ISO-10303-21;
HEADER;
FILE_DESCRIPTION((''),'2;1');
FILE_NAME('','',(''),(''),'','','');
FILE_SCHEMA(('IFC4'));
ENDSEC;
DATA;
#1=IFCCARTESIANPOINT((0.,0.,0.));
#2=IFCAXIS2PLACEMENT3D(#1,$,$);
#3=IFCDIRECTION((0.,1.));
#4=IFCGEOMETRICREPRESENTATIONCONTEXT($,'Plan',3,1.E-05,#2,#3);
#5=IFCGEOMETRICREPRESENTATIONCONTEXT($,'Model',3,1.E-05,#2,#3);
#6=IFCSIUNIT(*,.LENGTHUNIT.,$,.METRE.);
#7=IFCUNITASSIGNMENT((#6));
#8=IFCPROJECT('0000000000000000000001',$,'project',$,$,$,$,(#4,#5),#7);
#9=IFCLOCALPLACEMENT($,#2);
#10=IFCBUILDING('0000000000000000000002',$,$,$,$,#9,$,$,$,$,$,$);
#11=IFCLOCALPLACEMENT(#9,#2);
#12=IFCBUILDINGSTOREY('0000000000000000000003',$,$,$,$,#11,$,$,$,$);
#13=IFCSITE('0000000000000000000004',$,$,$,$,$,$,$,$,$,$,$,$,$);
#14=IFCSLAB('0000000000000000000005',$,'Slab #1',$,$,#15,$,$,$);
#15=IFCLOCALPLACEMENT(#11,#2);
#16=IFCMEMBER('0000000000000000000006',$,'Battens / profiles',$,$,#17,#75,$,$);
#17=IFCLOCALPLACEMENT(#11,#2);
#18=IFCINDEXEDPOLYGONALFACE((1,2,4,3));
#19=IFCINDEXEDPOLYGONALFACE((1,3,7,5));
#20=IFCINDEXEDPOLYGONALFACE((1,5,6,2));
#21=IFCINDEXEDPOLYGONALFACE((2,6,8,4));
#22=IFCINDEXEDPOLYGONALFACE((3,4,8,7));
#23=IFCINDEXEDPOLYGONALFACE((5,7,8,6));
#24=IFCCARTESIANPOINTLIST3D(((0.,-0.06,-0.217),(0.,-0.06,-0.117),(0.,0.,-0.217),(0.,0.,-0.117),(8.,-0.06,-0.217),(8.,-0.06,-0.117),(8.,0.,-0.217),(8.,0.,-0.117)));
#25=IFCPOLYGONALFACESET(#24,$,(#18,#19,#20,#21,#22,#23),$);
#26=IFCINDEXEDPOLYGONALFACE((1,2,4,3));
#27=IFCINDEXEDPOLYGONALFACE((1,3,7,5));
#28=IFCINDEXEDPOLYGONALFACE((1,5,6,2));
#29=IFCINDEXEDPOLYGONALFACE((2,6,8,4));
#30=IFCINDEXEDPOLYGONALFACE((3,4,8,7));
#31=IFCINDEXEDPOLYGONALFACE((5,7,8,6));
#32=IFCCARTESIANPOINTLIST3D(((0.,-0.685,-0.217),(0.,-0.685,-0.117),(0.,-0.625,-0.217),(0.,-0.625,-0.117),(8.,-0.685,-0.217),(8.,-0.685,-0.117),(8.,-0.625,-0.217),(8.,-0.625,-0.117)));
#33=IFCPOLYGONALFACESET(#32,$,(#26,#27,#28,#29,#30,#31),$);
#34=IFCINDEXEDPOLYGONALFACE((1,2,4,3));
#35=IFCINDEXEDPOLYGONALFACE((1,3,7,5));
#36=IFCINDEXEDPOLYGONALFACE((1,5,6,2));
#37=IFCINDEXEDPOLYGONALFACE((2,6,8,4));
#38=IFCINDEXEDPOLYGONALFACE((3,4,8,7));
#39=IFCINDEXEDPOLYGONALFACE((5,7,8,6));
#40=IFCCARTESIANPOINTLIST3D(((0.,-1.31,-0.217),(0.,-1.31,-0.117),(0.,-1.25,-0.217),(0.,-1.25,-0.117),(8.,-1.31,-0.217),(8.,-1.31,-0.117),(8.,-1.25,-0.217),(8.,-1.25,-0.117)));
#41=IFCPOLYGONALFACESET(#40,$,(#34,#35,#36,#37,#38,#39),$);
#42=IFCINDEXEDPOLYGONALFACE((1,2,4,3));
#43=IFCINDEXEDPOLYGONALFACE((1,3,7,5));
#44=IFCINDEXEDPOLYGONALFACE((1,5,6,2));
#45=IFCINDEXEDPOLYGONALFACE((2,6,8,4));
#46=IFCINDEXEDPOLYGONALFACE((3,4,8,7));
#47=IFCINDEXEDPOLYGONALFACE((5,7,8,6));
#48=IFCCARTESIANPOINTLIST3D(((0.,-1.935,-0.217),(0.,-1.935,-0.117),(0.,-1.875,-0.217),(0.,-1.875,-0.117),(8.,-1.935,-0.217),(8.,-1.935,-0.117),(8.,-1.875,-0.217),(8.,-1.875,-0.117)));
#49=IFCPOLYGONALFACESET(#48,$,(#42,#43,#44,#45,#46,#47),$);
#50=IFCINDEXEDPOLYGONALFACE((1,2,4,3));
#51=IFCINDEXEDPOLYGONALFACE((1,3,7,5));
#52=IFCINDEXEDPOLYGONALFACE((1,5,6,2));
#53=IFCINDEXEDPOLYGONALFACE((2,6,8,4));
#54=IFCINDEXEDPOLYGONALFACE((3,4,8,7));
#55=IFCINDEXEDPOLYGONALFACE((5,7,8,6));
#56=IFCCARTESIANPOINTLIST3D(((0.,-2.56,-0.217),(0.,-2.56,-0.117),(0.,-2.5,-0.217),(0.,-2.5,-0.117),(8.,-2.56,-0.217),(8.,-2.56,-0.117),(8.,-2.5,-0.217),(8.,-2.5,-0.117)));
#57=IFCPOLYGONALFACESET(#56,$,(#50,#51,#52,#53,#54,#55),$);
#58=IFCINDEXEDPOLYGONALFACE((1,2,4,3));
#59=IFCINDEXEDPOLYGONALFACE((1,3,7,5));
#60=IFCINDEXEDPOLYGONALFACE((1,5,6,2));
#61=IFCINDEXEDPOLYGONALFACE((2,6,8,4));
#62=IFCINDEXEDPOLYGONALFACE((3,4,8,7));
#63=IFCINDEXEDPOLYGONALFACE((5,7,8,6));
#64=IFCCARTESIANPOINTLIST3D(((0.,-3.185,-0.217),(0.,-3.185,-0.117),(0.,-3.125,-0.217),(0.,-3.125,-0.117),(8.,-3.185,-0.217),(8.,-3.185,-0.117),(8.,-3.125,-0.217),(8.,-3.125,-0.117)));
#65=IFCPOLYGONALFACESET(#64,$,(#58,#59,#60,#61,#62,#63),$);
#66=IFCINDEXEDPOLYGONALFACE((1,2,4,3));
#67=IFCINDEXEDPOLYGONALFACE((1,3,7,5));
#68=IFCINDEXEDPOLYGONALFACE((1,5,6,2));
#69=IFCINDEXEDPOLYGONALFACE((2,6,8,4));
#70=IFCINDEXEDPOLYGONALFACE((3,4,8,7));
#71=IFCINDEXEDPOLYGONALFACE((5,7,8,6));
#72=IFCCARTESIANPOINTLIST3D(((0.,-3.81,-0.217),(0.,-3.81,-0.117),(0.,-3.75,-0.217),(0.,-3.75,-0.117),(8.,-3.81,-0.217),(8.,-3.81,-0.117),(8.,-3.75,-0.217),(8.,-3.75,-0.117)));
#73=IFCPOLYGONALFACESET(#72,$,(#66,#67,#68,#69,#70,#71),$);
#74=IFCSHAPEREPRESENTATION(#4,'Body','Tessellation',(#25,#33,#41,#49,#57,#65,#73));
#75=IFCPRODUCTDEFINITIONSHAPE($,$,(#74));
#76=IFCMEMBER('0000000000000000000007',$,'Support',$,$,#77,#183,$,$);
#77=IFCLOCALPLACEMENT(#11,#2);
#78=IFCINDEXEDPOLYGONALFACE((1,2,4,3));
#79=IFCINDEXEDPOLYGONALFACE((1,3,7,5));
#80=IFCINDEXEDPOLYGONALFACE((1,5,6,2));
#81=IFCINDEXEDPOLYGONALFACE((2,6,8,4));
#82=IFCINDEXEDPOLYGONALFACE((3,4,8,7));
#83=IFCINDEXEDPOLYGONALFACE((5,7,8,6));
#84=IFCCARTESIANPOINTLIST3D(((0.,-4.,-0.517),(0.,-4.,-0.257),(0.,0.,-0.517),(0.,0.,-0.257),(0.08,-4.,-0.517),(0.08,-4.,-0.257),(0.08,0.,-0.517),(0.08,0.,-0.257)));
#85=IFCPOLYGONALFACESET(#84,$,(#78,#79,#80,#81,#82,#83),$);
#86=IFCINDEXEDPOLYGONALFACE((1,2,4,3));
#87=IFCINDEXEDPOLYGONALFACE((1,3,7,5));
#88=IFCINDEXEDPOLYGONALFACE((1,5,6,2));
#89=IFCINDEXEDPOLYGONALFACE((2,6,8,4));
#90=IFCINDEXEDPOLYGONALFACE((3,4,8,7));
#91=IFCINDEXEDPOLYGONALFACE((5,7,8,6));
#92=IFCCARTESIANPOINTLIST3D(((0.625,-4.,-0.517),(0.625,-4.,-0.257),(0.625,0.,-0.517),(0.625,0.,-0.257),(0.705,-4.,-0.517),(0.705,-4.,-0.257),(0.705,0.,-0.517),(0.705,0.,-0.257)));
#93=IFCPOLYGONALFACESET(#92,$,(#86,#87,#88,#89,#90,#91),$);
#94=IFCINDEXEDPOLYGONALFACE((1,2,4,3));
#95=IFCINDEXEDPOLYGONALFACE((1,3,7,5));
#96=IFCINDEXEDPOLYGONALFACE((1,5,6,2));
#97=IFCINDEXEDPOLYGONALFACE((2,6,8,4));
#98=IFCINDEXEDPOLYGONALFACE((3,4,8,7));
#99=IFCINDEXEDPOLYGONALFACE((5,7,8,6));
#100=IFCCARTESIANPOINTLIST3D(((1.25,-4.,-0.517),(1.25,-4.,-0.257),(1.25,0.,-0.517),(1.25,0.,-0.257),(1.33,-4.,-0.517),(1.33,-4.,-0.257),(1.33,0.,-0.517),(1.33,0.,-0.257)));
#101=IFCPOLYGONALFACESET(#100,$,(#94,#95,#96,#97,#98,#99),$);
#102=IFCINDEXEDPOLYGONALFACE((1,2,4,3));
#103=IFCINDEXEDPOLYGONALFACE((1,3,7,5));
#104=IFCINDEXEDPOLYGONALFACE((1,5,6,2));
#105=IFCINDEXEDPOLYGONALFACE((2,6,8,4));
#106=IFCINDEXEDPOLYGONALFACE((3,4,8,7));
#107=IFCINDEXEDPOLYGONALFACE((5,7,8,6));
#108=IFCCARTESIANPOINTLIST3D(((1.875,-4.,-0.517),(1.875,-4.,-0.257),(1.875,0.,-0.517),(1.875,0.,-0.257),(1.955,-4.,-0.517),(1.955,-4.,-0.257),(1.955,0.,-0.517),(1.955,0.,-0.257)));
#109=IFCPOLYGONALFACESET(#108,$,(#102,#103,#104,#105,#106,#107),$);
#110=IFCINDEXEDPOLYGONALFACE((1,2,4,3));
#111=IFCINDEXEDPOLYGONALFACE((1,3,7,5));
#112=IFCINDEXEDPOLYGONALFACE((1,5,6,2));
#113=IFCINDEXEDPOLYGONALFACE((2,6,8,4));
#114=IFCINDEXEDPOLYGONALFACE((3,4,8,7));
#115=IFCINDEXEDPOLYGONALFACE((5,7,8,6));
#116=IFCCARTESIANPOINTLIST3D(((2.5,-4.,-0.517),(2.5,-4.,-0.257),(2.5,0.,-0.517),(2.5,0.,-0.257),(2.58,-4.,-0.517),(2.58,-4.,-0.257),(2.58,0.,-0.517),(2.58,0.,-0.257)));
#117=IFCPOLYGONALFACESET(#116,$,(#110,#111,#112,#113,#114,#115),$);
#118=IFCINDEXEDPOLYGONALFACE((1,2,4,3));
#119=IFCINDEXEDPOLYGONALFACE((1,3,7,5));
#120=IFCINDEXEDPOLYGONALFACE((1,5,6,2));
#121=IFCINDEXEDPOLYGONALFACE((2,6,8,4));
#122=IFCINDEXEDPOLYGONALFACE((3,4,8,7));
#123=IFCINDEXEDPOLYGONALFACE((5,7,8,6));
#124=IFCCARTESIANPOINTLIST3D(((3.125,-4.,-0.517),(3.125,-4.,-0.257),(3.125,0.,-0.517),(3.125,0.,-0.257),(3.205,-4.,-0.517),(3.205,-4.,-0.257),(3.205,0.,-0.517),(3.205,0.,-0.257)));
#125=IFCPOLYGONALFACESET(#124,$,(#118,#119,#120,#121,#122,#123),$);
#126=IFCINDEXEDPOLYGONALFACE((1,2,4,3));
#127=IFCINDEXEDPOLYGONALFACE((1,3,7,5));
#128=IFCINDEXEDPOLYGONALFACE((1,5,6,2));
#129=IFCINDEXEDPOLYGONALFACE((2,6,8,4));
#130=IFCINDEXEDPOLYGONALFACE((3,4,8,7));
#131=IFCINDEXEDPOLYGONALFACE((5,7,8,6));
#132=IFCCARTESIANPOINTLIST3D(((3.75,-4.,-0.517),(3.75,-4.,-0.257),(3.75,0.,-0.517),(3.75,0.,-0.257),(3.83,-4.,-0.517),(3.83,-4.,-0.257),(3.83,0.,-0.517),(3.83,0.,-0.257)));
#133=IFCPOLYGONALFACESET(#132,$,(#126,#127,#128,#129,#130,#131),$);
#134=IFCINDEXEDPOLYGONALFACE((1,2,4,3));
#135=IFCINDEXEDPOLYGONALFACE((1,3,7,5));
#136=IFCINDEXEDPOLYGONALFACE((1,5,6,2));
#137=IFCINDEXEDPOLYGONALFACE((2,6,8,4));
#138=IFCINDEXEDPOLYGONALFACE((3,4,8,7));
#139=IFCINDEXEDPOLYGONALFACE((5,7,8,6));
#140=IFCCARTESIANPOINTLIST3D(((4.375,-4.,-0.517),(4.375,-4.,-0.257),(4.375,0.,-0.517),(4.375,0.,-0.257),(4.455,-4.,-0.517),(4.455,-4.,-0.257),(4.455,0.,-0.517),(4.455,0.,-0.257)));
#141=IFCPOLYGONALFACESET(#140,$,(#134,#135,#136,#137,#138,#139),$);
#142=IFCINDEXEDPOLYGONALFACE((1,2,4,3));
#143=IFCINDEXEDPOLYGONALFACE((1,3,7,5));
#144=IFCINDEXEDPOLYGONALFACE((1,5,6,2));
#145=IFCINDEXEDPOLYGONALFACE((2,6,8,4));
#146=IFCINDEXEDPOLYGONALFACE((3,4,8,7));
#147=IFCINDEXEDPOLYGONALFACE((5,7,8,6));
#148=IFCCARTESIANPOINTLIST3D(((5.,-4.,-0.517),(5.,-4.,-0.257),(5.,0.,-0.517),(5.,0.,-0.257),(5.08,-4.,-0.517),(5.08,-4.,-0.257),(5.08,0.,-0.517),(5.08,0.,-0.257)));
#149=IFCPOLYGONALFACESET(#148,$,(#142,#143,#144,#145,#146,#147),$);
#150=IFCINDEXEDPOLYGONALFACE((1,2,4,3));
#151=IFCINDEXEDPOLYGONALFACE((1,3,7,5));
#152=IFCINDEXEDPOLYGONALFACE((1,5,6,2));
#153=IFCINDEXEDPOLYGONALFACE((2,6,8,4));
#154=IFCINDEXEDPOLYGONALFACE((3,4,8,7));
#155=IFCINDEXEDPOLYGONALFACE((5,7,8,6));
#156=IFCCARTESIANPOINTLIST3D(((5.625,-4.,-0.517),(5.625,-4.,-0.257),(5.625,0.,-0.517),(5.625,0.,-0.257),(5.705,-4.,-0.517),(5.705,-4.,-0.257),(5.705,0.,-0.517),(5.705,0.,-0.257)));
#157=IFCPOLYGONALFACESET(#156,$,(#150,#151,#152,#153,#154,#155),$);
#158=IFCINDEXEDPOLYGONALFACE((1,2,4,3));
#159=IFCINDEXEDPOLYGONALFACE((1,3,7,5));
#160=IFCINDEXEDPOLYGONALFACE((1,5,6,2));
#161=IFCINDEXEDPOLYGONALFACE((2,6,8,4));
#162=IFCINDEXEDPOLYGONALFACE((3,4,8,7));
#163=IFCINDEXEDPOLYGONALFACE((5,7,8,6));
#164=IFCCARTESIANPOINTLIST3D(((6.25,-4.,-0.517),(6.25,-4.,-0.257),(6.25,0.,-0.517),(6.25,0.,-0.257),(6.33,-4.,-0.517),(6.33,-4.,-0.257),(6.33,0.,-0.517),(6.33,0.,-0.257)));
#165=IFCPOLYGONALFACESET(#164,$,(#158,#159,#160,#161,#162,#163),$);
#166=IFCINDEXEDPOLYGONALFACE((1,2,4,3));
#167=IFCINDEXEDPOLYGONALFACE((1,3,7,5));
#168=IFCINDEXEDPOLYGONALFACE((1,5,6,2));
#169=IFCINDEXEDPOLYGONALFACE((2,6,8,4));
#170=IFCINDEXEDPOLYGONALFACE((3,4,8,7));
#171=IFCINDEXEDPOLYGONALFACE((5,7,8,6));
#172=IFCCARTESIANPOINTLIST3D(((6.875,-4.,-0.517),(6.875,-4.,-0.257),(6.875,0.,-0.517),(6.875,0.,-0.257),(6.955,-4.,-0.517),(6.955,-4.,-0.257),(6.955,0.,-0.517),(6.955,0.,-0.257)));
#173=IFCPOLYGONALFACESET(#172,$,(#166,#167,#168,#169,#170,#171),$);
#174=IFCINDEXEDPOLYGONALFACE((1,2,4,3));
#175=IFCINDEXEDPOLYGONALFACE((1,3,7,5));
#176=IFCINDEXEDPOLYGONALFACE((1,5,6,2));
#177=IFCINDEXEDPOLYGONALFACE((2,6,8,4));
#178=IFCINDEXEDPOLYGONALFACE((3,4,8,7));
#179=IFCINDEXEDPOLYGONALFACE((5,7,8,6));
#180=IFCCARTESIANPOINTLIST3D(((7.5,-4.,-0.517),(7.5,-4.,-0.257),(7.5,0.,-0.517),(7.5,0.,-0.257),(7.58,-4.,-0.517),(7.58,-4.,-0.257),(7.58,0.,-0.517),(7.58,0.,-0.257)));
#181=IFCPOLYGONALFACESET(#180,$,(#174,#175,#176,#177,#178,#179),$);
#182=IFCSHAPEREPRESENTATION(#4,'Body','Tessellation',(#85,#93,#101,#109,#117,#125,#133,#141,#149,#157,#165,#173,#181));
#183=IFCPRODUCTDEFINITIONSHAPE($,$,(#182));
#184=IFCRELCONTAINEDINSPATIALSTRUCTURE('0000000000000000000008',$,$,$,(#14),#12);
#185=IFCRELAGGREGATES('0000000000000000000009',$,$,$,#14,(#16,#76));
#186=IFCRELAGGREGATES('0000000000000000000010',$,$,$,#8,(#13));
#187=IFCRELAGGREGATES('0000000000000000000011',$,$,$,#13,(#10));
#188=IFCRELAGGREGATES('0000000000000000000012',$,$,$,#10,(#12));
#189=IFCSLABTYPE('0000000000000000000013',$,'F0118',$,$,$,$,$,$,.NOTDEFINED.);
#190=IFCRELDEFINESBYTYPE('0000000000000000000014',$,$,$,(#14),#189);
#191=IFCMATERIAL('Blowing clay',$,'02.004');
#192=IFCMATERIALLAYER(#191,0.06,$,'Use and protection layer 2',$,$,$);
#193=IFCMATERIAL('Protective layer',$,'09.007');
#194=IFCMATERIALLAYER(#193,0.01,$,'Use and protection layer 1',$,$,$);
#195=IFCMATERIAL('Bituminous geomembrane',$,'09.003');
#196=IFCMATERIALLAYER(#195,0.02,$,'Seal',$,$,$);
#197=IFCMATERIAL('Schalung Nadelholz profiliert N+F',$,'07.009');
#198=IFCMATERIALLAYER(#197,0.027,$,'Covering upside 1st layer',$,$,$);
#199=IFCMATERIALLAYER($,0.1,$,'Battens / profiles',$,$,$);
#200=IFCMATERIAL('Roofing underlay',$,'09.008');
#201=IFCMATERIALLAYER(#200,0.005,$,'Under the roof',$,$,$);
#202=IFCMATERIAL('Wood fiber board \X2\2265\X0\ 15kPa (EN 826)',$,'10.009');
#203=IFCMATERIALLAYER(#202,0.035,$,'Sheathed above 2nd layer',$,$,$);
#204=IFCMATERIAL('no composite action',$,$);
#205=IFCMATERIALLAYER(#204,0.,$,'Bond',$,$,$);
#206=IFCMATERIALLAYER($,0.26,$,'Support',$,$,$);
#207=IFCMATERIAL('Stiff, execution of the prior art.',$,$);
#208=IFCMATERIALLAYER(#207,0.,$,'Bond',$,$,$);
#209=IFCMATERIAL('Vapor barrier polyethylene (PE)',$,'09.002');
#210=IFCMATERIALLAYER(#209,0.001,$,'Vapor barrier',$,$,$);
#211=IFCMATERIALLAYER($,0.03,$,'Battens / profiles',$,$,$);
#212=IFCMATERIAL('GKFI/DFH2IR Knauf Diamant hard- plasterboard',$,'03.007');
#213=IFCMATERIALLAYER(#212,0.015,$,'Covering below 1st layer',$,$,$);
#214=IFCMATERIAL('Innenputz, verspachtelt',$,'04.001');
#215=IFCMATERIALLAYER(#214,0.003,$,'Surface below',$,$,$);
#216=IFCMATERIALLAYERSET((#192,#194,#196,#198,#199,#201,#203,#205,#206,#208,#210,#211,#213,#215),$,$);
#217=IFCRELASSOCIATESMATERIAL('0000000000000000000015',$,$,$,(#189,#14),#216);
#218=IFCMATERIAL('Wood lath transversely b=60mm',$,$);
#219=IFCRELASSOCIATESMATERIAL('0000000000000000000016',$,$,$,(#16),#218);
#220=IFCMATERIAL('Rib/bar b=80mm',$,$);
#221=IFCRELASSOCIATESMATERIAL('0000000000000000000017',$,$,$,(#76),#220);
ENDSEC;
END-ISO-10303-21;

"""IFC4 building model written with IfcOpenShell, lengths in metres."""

from ifc_helpers import new_model, si_unit, direction, frame, frame_2d, origin, place, context, project, spatial, rectangle, extrude, material, layer, layer_set, type_object, element, aggregate, save


model = new_model("IFC4")

# Units and contexts
plan_context = context("Plan", 3, precision=1e-05, world=origin(), true_north=direction((0.0, 1.0)))
model_context = context("Model", 3, precision=1e-05, world=origin(), true_north=direction((0.0, 1.0)))
ifc_project = project(units=[si_unit("LENGTHUNIT", "METRE")], contexts=[plan_context, model_context])

# Site, building, storey
site = spatial("IfcSite", under=ifc_project)
building_placement = place(None, origin())
building = spatial("IfcBuilding", under=site, at=building_placement)
storey_placement = place(building_placement, origin())
storey = spatial("IfcBuildingStorey", under=building, at=storey_placement)

# Slab, members
ifc_material_1 = material(Name="Blowing clay", Category="02.004")
ifc_layer_1 = layer(ifc_material_1, 0.06, Name="Use and protection layer 2")
ifc_material_2 = material(Name="Protective layer", Category="09.007")
ifc_layer_2 = layer(ifc_material_2, 0.01, Name="Use and protection layer 1")
ifc_material_3 = material(Name="Bituminous geomembrane", Category="09.003")
ifc_layer_3 = layer(ifc_material_3, 0.02, Name="Seal")
ifc_material_4 = material(Name="Schalung Nadelholz profiliert N+F", Category="07.009")
ifc_layer_4 = layer(ifc_material_4, 0.027, Name="Covering upside 1st layer")
ifc_layer_5 = layer(None, 0.1, Name="Battens / profiles")
ifc_material_5 = material(Name="Roofing underlay", Category="09.008")
ifc_layer_6 = layer(ifc_material_5, 0.005, Name="Under the roof")
ifc_material_6 = material(Name="Wood fiber board ≥ 15kPa (EN 826)", Category="10.009")
ifc_layer_7 = layer(ifc_material_6, 0.035, Name="Sheathed above 2nd layer")
ifc_material_7 = material(Name="no composite action")
ifc_layer_8 = layer(ifc_material_7, 0.0, Name="Bond")
ifc_layer_9 = layer(None, 0.26, Name="Support")
ifc_material_8 = material(Name="Stiff, execution of the prior art.")
ifc_layer_10 = layer(ifc_material_8, 0.0, Name="Bond")
ifc_material_9 = material(Name="Vapor barrier polyethylene (PE)", Category="09.002")
ifc_layer_11 = layer(ifc_material_9, 0.001, Name="Vapor barrier")
ifc_layer_12 = layer(None, 0.03, Name="Battens / profiles")
ifc_material_10 = material(Name="GKFI/DFH2IR Knauf Diamant hard- plasterboard", Category="03.007")
ifc_layer_13 = layer(ifc_material_10, 0.015, Name="Covering below 1st layer")
ifc_material_11 = material(Name="Innenputz, verspachtelt", Category="04.001")
ifc_layer_14 = layer(ifc_material_11, 0.003, Name="Surface below")
ifc_layer_set = layer_set([ifc_layer_1, ifc_layer_2, ifc_layer_3, ifc_layer_4, ifc_layer_5, ifc_layer_6, ifc_layer_7, ifc_layer_8, ifc_layer_9, ifc_layer_10, ifc_layer_11, ifc_layer_12, ifc_layer_13, ifc_layer_14])
slab_type = type_object("IfcSlabType", Name="F0118", PredefinedType="NOTDEFINED", material=ifc_layer_set)
slab_placement = place(None, frame((0.0, 0.0, 0.0), z_axis=(0.0, 0.0, -1.0), x_axis=(1.0, 0.0, 0.0)))
slab = element("IfcSlab", 1, at=slab_placement, inside=storey, type_object=slab_type, material=ifc_layer_set, Name="Slab #1")
ifc_material_12 = material(Name="Wood lath transversely b=60mm")
member_1_placement = place(slab_placement, origin())
member_1 = element("IfcMember", 2, at=member_1_placement, material=ifc_material_12, Name="Battens / profiles", context=plan_context, shape_type="SweptSolid", body=[
    extrude(rectangle(XDim=0.06, YDim=0.1, at=frame_2d((0.03, 0.05), x_axis=(1.0, 0.0))), frame((0.0, 0.0, 0.117), z_axis=(1.0, 0.0, 0.0), x_axis=(0.0, 1.0, 0.0)), (0.0, 0.0, 1.0), 8.0),
    extrude(rectangle(XDim=0.06, YDim=0.1, at=frame_2d((0.03, 0.05), x_axis=(1.0, 0.0))), frame((0.0, 0.625, 0.117), z_axis=(1.0, 0.0, 0.0), x_axis=(0.0, 1.0, 0.0)), (0.0, 0.0, 1.0), 8.0),
    extrude(rectangle(XDim=0.06, YDim=0.1, at=frame_2d((0.03, 0.05), x_axis=(1.0, 0.0))), frame((0.0, 1.25, 0.117), z_axis=(1.0, 0.0, 0.0), x_axis=(0.0, 1.0, 0.0)), (0.0, 0.0, 1.0), 8.0),
    extrude(rectangle(XDim=0.06, YDim=0.1, at=frame_2d((0.03, 0.05), x_axis=(1.0, 0.0))), frame((0.0, 1.875, 0.117), z_axis=(1.0, 0.0, 0.0), x_axis=(0.0, 1.0, 0.0)), (0.0, 0.0, 1.0), 8.0),
    extrude(rectangle(XDim=0.06, YDim=0.1, at=frame_2d((0.03, 0.05), x_axis=(1.0, 0.0))), frame((0.0, 2.5, 0.117), z_axis=(1.0, 0.0, 0.0), x_axis=(0.0, 1.0, 0.0)), (0.0, 0.0, 1.0), 8.0),
    extrude(rectangle(XDim=0.06, YDim=0.1, at=frame_2d((0.03, 0.05), x_axis=(1.0, 0.0))), frame((0.0, 3.125, 0.117), z_axis=(1.0, 0.0, 0.0), x_axis=(0.0, 1.0, 0.0)), (0.0, 0.0, 1.0), 8.0),
    extrude(rectangle(XDim=0.06, YDim=0.1, at=frame_2d((0.03, 0.05), x_axis=(1.0, 0.0))), frame((0.0, 3.75, 0.117), z_axis=(1.0, 0.0, 0.0), x_axis=(0.0, 1.0, 0.0)), (0.0, 0.0, 1.0), 8.0),
])
ifc_material_13 = material(Name="Rib/bar b=80mm")
member_2_placement = place(slab_placement, origin())
member_2 = element("IfcMember", 3, at=member_2_placement, material=ifc_material_13, Name="Support", context=plan_context, shape_type="SweptSolid", body=[
    extrude(rectangle(XDim=0.08, YDim=0.26, at=frame_2d((0.04, 0.13), x_axis=(1.0, 0.0))), frame((0.0, 4.0, 0.257), z_axis=(0.0, -1.0, 0.0), x_axis=(1.0, 0.0, 0.0)), (0.0, 0.0, 1.0), 4.0),
    extrude(rectangle(XDim=0.08, YDim=0.26, at=frame_2d((0.04, 0.13), x_axis=(1.0, 0.0))), frame((0.625, 4.0, 0.257), z_axis=(0.0, -1.0, 0.0), x_axis=(1.0, 0.0, 0.0)), (0.0, 0.0, 1.0), 4.0),
    extrude(rectangle(XDim=0.08, YDim=0.26, at=frame_2d((0.04, 0.13), x_axis=(1.0, 0.0))), frame((1.25, 4.0, 0.257), z_axis=(0.0, -1.0, 0.0), x_axis=(1.0, 0.0, 0.0)), (0.0, 0.0, 1.0), 4.0),
    extrude(rectangle(XDim=0.08, YDim=0.26, at=frame_2d((0.04, 0.13), x_axis=(1.0, 0.0))), frame((1.875, 4.0, 0.257), z_axis=(0.0, -1.0, 0.0), x_axis=(1.0, 0.0, 0.0)), (0.0, 0.0, 1.0), 4.0),
    extrude(rectangle(XDim=0.08, YDim=0.26, at=frame_2d((0.04, 0.13), x_axis=(1.0, 0.0))), frame((2.5, 4.0, 0.257), z_axis=(0.0, -1.0, 0.0), x_axis=(1.0, 0.0, 0.0)), (0.0, 0.0, 1.0), 4.0),
    extrude(rectangle(XDim=0.08, YDim=0.26, at=frame_2d((0.04, 0.13), x_axis=(1.0, 0.0))), frame((3.125, 4.0, 0.257), z_axis=(0.0, -1.0, 0.0), x_axis=(1.0, 0.0, 0.0)), (0.0, 0.0, 1.0), 4.0),
    extrude(rectangle(XDim=0.08, YDim=0.26, at=frame_2d((0.04, 0.13), x_axis=(1.0, 0.0))), frame((3.75, 4.0, 0.257), z_axis=(0.0, -1.0, 0.0), x_axis=(1.0, 0.0, 0.0)), (0.0, 0.0, 1.0), 4.0),
    extrude(rectangle(XDim=0.08, YDim=0.26, at=frame_2d((0.04, 0.13), x_axis=(1.0, 0.0))), frame((4.375, 4.0, 0.257), z_axis=(0.0, -1.0, 0.0), x_axis=(1.0, 0.0, 0.0)), (0.0, 0.0, 1.0), 4.0),
    extrude(rectangle(XDim=0.08, YDim=0.26, at=frame_2d((0.04, 0.13), x_axis=(1.0, 0.0))), frame((5.0, 4.0, 0.257), z_axis=(0.0, -1.0, 0.0), x_axis=(1.0, 0.0, 0.0)), (0.0, 0.0, 1.0), 4.0),
    extrude(rectangle(XDim=0.08, YDim=0.26, at=frame_2d((0.04, 0.13), x_axis=(1.0, 0.0))), frame((5.625, 4.0, 0.257), z_axis=(0.0, -1.0, 0.0), x_axis=(1.0, 0.0, 0.0)), (0.0, 0.0, 1.0), 4.0),
    extrude(rectangle(XDim=0.08, YDim=0.26, at=frame_2d((0.04, 0.13), x_axis=(1.0, 0.0))), frame((6.25, 4.0, 0.257), z_axis=(0.0, -1.0, 0.0), x_axis=(1.0, 0.0, 0.0)), (0.0, 0.0, 1.0), 4.0),
    extrude(rectangle(XDim=0.08, YDim=0.26, at=frame_2d((0.04, 0.13), x_axis=(1.0, 0.0))), frame((6.875, 4.0, 0.257), z_axis=(0.0, -1.0, 0.0), x_axis=(1.0, 0.0, 0.0)), (0.0, 0.0, 1.0), 4.0),
    extrude(rectangle(XDim=0.08, YDim=0.26, at=frame_2d((0.04, 0.13), x_axis=(1.0, 0.0))), frame((7.5, 4.0, 0.257), z_axis=(0.0, -1.0, 0.0), x_axis=(1.0, 0.0, 0.0)), (0.0, 0.0, 1.0), 4.0),
])
aggregate(slab, [member_1, member_2])

save(model, "model.ifc")
